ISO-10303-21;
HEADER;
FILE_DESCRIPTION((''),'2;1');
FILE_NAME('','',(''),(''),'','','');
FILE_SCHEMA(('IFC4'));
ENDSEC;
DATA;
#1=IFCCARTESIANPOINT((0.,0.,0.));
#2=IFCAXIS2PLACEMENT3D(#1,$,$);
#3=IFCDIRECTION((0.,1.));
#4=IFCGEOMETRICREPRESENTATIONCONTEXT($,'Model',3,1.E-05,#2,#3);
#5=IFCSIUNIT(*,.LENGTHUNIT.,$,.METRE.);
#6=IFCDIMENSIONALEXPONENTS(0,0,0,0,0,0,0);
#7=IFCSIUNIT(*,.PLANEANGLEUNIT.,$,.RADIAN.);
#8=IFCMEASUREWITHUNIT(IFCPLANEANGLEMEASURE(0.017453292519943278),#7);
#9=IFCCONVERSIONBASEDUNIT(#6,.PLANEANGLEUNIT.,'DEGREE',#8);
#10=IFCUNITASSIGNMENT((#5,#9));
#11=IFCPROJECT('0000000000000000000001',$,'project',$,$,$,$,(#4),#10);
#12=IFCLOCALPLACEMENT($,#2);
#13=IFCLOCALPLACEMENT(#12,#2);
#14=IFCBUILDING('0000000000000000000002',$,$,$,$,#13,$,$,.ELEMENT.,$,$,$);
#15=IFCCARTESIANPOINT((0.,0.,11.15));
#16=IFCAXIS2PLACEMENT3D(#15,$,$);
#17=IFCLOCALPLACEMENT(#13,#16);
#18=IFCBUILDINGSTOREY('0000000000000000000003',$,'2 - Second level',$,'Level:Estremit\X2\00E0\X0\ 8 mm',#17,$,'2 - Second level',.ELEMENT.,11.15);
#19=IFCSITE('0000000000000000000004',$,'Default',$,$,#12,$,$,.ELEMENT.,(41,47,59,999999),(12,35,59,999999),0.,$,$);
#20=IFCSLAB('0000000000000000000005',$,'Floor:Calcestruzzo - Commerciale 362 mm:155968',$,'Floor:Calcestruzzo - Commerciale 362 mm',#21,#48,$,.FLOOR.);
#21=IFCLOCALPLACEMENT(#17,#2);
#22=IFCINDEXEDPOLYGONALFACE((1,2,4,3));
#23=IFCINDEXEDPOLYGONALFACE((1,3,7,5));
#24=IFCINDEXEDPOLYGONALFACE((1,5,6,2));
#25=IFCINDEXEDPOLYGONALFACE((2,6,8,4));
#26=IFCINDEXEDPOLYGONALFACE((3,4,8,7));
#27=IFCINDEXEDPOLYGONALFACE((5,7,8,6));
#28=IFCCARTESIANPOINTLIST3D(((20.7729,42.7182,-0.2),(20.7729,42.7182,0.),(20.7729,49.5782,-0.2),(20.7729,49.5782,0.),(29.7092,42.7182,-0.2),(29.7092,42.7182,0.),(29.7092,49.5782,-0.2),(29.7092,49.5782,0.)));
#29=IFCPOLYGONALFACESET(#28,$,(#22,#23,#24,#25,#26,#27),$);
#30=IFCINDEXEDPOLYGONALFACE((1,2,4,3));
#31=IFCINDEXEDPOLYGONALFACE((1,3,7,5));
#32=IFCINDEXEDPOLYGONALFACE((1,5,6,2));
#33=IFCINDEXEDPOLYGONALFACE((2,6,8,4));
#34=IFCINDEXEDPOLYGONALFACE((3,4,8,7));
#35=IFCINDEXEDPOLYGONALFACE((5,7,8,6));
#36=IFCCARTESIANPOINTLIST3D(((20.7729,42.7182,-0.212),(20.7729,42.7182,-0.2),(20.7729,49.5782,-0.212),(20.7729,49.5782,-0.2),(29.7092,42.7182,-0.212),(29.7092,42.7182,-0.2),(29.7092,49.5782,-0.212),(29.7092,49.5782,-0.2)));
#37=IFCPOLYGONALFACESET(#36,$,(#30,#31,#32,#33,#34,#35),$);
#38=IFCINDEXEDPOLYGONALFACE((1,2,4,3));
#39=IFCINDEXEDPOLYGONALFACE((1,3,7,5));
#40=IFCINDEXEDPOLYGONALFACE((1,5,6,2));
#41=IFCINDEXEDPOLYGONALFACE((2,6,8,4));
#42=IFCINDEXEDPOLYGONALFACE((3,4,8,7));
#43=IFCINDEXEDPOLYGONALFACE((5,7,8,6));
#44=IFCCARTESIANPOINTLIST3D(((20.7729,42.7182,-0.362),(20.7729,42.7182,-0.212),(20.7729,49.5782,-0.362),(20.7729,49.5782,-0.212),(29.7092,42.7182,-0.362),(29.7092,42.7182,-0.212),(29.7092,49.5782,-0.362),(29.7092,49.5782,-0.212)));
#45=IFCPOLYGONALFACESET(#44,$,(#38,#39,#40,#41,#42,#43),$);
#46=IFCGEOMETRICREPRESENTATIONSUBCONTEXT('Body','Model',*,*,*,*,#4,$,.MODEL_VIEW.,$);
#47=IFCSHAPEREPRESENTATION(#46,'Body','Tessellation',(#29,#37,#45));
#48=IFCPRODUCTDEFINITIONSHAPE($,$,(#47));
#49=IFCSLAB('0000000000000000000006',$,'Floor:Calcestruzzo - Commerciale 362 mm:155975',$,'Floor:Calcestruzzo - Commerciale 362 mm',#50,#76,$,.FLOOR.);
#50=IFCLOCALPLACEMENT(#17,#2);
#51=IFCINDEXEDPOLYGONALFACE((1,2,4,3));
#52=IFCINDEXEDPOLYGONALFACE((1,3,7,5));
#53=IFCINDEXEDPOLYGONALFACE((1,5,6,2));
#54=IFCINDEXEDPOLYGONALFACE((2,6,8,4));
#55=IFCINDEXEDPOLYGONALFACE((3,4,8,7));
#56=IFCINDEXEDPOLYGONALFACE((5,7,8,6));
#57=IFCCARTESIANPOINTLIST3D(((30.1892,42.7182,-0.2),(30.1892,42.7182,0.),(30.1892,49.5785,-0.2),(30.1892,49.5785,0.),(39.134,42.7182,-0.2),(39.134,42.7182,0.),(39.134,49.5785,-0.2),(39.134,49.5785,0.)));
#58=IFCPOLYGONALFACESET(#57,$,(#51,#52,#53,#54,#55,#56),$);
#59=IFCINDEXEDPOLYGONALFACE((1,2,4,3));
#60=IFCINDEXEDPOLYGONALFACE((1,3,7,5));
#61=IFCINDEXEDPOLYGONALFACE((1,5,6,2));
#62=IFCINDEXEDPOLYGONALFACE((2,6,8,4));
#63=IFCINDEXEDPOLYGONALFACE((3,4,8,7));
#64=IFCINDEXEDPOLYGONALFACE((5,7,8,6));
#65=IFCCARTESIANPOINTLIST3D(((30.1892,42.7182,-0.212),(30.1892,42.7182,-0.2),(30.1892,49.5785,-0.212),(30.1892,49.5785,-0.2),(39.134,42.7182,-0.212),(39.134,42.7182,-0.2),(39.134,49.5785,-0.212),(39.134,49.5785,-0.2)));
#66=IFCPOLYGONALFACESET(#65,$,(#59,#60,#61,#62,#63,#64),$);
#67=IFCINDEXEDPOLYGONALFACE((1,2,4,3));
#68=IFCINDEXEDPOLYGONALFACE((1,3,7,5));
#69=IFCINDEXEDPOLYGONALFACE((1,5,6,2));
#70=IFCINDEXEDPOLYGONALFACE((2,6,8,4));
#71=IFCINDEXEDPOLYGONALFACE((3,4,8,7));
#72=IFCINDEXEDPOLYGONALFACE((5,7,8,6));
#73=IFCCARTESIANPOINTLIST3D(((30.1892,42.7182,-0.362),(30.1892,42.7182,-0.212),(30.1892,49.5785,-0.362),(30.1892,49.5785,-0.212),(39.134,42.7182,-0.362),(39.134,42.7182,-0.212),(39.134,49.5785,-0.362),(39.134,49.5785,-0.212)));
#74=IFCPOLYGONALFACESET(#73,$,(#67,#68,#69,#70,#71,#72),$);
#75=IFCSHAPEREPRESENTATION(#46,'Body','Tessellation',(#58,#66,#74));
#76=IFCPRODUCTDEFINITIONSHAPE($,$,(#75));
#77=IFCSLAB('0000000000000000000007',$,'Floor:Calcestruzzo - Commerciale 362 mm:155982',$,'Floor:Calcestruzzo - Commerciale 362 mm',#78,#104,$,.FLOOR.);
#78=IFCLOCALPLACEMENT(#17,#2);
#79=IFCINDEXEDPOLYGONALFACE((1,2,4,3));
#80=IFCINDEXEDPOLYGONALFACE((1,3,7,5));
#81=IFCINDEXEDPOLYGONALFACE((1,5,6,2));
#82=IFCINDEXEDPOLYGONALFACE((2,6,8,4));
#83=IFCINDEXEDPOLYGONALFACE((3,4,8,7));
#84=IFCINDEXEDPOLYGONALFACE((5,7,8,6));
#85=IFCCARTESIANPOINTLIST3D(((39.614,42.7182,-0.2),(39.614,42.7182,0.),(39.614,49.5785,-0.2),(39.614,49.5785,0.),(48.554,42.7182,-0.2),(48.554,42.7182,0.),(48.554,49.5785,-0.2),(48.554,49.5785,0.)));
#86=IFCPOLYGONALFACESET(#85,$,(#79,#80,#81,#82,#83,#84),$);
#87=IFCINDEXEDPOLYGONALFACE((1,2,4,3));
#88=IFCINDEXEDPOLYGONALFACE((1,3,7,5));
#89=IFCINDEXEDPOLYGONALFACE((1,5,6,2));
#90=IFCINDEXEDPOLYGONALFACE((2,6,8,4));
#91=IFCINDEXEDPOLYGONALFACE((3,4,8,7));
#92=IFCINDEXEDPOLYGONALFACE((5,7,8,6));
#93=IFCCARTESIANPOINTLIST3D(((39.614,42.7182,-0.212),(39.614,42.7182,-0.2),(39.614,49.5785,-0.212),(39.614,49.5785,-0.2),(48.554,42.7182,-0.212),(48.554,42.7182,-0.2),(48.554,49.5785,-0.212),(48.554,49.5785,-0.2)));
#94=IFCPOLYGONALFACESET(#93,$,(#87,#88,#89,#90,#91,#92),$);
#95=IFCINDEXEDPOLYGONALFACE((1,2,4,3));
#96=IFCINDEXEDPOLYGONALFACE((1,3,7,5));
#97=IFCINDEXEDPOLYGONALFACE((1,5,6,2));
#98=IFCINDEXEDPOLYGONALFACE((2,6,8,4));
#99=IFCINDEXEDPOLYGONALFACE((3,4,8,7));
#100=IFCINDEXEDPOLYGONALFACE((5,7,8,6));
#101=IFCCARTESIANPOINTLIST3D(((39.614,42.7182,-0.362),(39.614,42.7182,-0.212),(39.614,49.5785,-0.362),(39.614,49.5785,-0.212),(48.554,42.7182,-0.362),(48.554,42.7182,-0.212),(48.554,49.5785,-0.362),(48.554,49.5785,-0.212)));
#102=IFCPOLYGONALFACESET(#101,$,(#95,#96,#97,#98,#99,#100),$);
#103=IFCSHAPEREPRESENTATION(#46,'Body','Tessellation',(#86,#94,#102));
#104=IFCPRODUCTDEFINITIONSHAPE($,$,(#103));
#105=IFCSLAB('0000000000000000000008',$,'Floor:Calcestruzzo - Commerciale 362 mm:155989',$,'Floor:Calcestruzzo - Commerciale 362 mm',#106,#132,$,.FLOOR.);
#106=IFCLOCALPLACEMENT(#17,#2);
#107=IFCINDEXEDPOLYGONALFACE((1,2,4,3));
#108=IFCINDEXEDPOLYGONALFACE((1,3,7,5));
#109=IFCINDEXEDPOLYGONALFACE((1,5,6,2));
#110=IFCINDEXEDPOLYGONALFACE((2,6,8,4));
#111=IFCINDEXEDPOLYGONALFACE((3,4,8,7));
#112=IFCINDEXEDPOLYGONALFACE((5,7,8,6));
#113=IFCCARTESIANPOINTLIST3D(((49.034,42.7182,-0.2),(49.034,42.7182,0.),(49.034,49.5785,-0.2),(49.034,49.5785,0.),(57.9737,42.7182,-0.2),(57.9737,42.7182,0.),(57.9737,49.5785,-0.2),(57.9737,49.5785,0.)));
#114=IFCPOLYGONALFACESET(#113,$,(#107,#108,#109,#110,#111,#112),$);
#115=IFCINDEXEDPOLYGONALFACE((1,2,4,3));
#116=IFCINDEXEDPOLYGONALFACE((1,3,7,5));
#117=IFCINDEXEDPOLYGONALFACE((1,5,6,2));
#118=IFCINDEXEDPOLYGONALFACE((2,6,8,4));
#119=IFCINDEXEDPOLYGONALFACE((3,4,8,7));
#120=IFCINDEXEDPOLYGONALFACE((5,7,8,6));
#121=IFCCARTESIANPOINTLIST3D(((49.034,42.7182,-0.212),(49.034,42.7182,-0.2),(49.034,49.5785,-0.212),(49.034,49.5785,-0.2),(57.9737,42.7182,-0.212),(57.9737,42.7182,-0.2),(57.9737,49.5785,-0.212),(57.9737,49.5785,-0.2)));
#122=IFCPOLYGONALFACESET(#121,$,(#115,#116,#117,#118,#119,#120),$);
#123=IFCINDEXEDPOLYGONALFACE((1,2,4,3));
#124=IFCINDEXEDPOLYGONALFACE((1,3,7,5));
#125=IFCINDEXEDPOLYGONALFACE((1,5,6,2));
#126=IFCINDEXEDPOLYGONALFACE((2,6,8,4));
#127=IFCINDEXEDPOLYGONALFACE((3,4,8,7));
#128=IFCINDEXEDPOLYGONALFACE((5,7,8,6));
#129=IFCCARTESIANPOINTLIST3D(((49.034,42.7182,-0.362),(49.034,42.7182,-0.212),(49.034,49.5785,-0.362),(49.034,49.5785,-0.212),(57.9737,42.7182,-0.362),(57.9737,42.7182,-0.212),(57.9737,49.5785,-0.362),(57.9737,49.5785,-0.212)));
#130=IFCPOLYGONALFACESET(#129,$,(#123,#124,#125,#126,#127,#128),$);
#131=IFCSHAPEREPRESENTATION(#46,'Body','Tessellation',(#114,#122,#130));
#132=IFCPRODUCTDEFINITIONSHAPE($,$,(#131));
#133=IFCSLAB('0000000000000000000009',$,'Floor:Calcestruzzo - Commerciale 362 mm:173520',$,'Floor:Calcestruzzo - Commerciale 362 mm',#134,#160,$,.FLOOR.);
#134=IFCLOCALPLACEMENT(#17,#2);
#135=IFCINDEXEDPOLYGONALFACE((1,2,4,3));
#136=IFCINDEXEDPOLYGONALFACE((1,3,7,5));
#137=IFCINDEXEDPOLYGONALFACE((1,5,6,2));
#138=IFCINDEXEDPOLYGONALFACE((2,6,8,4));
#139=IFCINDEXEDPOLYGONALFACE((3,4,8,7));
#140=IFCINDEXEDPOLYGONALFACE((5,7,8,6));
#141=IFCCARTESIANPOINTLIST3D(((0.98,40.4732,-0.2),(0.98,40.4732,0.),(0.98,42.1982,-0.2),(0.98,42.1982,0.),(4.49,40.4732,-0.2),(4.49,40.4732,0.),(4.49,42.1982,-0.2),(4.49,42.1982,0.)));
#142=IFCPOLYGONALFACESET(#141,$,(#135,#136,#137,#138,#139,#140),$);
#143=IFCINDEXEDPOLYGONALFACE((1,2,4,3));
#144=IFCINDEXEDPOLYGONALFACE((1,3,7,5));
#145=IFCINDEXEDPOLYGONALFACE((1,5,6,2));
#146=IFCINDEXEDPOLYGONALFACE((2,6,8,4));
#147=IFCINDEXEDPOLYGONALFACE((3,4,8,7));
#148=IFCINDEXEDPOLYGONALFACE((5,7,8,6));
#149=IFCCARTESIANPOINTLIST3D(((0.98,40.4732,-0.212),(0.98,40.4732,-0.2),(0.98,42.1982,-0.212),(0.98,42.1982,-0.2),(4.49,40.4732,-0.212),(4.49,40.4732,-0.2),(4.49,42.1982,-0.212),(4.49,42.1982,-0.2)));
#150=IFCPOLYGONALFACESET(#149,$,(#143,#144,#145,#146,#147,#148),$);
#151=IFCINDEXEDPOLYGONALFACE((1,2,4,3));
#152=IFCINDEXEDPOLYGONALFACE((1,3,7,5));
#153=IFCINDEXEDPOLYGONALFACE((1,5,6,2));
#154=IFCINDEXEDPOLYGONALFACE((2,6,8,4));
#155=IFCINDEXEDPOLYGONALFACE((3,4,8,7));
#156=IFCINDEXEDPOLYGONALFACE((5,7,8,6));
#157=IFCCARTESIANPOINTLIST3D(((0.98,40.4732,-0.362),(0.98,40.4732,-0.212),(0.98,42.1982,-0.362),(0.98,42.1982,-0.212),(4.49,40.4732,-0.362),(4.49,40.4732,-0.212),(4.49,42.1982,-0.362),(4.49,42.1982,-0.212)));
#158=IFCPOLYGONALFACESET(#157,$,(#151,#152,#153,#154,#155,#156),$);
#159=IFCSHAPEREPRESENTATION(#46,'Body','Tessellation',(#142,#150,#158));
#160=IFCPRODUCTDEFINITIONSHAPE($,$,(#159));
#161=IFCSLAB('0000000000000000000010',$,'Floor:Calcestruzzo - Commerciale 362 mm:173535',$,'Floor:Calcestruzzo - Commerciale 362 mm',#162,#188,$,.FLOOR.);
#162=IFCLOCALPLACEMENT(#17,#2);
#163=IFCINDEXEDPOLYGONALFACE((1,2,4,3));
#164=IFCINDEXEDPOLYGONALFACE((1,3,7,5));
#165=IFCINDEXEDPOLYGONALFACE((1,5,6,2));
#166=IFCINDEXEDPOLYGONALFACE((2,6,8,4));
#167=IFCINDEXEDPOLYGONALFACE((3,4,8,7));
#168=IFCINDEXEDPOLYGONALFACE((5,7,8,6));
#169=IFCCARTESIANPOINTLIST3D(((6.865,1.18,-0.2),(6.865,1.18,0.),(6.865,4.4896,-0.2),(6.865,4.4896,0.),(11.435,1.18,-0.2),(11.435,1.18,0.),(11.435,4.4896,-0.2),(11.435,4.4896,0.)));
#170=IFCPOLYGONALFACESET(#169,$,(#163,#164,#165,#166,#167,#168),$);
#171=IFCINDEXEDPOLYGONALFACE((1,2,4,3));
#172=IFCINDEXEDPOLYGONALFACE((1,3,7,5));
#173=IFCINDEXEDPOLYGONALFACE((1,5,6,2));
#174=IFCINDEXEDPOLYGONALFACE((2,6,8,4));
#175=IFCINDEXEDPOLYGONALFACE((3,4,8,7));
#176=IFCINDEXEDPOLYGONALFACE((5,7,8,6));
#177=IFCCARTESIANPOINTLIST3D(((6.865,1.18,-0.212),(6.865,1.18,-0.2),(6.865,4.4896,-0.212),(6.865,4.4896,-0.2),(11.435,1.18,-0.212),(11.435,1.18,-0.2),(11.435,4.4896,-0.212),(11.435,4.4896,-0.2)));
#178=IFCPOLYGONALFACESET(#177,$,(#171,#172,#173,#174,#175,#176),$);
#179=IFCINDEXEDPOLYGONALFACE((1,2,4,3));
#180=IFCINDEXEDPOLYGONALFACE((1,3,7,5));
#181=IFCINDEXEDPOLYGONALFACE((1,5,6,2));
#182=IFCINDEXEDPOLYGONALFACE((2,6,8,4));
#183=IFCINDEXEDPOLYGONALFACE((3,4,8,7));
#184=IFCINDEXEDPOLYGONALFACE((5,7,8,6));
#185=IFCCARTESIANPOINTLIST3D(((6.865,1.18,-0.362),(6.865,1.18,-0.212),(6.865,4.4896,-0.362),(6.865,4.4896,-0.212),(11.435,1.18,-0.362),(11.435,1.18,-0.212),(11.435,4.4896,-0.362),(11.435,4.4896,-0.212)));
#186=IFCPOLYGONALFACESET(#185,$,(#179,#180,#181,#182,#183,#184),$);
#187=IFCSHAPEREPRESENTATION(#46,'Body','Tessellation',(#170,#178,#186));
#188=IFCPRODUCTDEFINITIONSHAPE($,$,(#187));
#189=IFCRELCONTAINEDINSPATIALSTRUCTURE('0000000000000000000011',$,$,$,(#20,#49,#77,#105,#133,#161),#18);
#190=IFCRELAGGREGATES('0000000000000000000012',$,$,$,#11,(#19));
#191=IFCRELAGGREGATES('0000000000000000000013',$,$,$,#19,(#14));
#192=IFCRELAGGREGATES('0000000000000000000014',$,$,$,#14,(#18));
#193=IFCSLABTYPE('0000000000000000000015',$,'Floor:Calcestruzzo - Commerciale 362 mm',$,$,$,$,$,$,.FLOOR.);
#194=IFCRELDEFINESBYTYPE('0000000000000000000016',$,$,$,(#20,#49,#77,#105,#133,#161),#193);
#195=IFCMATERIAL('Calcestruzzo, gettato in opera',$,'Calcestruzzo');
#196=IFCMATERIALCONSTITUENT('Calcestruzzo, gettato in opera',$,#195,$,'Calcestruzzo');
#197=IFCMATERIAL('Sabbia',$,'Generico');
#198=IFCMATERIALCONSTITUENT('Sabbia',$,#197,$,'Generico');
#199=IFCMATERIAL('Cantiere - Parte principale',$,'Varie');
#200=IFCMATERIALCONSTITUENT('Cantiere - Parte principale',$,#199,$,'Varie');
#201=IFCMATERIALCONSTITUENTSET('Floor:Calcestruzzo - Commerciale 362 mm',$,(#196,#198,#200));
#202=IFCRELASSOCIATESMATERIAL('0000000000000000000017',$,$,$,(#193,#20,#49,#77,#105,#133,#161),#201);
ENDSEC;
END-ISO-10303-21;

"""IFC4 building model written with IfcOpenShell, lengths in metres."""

from ifc_helpers import new_model, entity, si_unit, converted_unit, direction, frame, origin, place, context, subcontext, project, spatial, indexed_curve, outline, extrude, material, constituent, constituent_set, type_object, element, save


model = new_model("IFC4")

# Units and contexts
model_context = context("Model", 3, precision=1e-05, world=origin(), true_north=direction((0.0, 1.0)))
body_context = subcontext(model_context, "Body", "Model", "MODEL_VIEW")
ifc_project = project(units=[si_unit("LENGTHUNIT", "METRE"), converted_unit("PLANEANGLEUNIT", "DEGREE", entity("IfcPlaneAngleMeasure", 0.017453292519943278), si_unit("PLANEANGLEUNIT", "RADIAN"), dimensions=[0, 0, 0, 0, 0, 0, 0])], contexts=[model_context])

# Site, building, storey
site_placement = place(None, origin())
site = spatial("IfcSite", under=ifc_project, at=site_placement, Name="Default", CompositionType="ELEMENT", RefLatitude=(41, 47, 59, 999999), RefLongitude=(12, 35, 59, 999999), RefElevation=0.0)
building_placement = place(site_placement, origin())
building = spatial("IfcBuilding", under=site, at=building_placement, CompositionType="ELEMENT")
storey_placement = place(building_placement, frame((0.0, 0.0, 11.15)))
storey = spatial("IfcBuildingStorey", under=building, at=storey_placement, Name="2 - Second level", ObjectType="Level:Estremità 8 mm", LongName="2 - Second level", CompositionType="ELEMENT", Elevation=11.15)

# Slabs
ifc_material_1 = material(Name="Calcestruzzo, gettato in opera", Category="Calcestruzzo")
ifc_constituent_1 = constituent(ifc_material_1, Name="Calcestruzzo, gettato in opera", Category="Calcestruzzo")
ifc_material_2 = material(Name="Sabbia", Category="Generico")
ifc_constituent_2 = constituent(ifc_material_2, Name="Sabbia", Category="Generico")
ifc_material_3 = material(Name="Cantiere - Parte principale", Category="Varie")
ifc_constituent_3 = constituent(ifc_material_3, Name="Cantiere - Parte principale", Category="Varie")
ifc_constituent_set = constituent_set(constituents=[ifc_constituent_1, ifc_constituent_2, ifc_constituent_3], Name="Floor:Calcestruzzo - Commerciale 362 mm")
slab_type = type_object("IfcSlabType", Name="Floor:Calcestruzzo - Commerciale 362 mm", PredefinedType="FLOOR", material=ifc_constituent_set)
slab_1_placement = place(storey_placement, origin())
element("IfcSlab", 1, at=slab_1_placement, inside=storey, type_object=slab_type, material=ifc_constituent_set, Name="Floor:Calcestruzzo - Commerciale 362 mm:155968", ObjectType="Floor:Calcestruzzo - Commerciale 362 mm", PredefinedType="FLOOR", context=body_context, shape_type="SweptSolid", body=[
    extrude(outline(indexed_curve([(-3.43, -4.4681), (3.43, -4.4681), (3.43, 4.4681), (-3.43, 4.4681), (-3.43, -4.4681)], self_intersect=False)), frame((25.2411, 46.1482, -0.2), z_axis=(0.0, 0.0, 1.0), x_axis=(0.0, -1.0, 0.0)), (0.0, 0.0, 1.0), 0.2),
    extrude(outline(indexed_curve([(-3.43, -4.4681), (3.43, -4.4681), (3.43, 4.4681), (-3.43, 4.4681), (-3.43, -4.4681)], self_intersect=False)), frame((25.2411, 46.1482, -0.212), z_axis=(0.0, 0.0, 1.0), x_axis=(0.0, -1.0, 0.0)), (0.0, 0.0, 1.0), 0.012),
    extrude(outline(indexed_curve([(-3.43, -4.4681), (3.43, -4.4681), (3.43, 4.4681), (-3.43, 4.4681), (-3.43, -4.4681)], self_intersect=False)), frame((25.2411, 46.1482, -0.362), z_axis=(0.0, 0.0, 1.0), x_axis=(0.0, -1.0, 0.0)), (0.0, 0.0, 1.0), 0.15),
])
slab_2_placement = place(storey_placement, origin())
element("IfcSlab", 2, at=slab_2_placement, inside=storey, type_object=slab_type, material=ifc_constituent_set, Name="Floor:Calcestruzzo - Commerciale 362 mm:155975", ObjectType="Floor:Calcestruzzo - Commerciale 362 mm", PredefinedType="FLOOR", context=body_context, shape_type="SweptSolid", body=[
    extrude(outline(indexed_curve([(-3.4302, -4.4724), (3.4302, -4.4724), (3.4302, 4.4724), (-3.4302, 4.4724), (-3.4302, -4.4724)], self_intersect=False)), frame((34.6616, 46.1483, -0.2), z_axis=(0.0, 0.0, 1.0), x_axis=(0.0, -1.0, 0.0)), (0.0, 0.0, 1.0), 0.2),
    extrude(outline(indexed_curve([(-3.4302, -4.4724), (3.4302, -4.4724), (3.4302, 4.4724), (-3.4302, 4.4724), (-3.4302, -4.4724)], self_intersect=False)), frame((34.6616, 46.1483, -0.212), z_axis=(0.0, 0.0, 1.0), x_axis=(0.0, -1.0, 0.0)), (0.0, 0.0, 1.0), 0.012),
    extrude(outline(indexed_curve([(-3.4302, -4.4724), (3.4302, -4.4724), (3.4302, 4.4724), (-3.4302, 4.4724), (-3.4302, -4.4724)], self_intersect=False)), frame((34.6616, 46.1483, -0.362), z_axis=(0.0, 0.0, 1.0), x_axis=(0.0, -1.0, 0.0)), (0.0, 0.0, 1.0), 0.15),
])
slab_3_placement = place(storey_placement, origin())
element("IfcSlab", 3, at=slab_3_placement, inside=storey, type_object=slab_type, material=ifc_constituent_set, Name="Floor:Calcestruzzo - Commerciale 362 mm:155982", ObjectType="Floor:Calcestruzzo - Commerciale 362 mm", PredefinedType="FLOOR", context=body_context, shape_type="SweptSolid", body=[
    extrude(outline(indexed_curve([(-3.4302, -4.47), (3.4302, -4.47), (3.4302, 4.47), (-3.4302, 4.47), (-3.4302, -4.47)], self_intersect=False)), frame((44.084, 46.1483, -0.2), z_axis=(0.0, 0.0, 1.0), x_axis=(0.0, -1.0, 0.0)), (0.0, 0.0, 1.0), 0.2),
    extrude(outline(indexed_curve([(-3.4302, -4.47), (3.4302, -4.47), (3.4302, 4.47), (-3.4302, 4.47), (-3.4302, -4.47)], self_intersect=False)), frame((44.084, 46.1483, -0.212), z_axis=(0.0, 0.0, 1.0), x_axis=(0.0, -1.0, 0.0)), (0.0, 0.0, 1.0), 0.012),
    extrude(outline(indexed_curve([(-3.4302, -4.47), (3.4302, -4.47), (3.4302, 4.47), (-3.4302, 4.47), (-3.4302, -4.47)], self_intersect=False)), frame((44.084, 46.1483, -0.362), z_axis=(0.0, 0.0, 1.0), x_axis=(0.0, -1.0, 0.0)), (0.0, 0.0, 1.0), 0.15),
])
slab_4_placement = place(storey_placement, origin())
element("IfcSlab", 4, at=slab_4_placement, inside=storey, type_object=slab_type, material=ifc_constituent_set, Name="Floor:Calcestruzzo - Commerciale 362 mm:155989", ObjectType="Floor:Calcestruzzo - Commerciale 362 mm", PredefinedType="FLOOR", context=body_context, shape_type="SweptSolid", body=[
    extrude(outline(indexed_curve([(-3.4302, -4.4698), (3.4302, -4.4698), (3.4302, 4.4698), (-3.4302, 4.4698), (-3.4302, -4.4698)], self_intersect=False)), frame((53.5038, 46.1483, -0.2), z_axis=(0.0, 0.0, 1.0), x_axis=(0.0, -1.0, 0.0)), (0.0, 0.0, 1.0), 0.2),
    extrude(outline(indexed_curve([(-3.4302, -4.4698), (3.4302, -4.4698), (3.4302, 4.4698), (-3.4302, 4.4698), (-3.4302, -4.4698)], self_intersect=False)), frame((53.5038, 46.1483, -0.212), z_axis=(0.0, 0.0, 1.0), x_axis=(0.0, -1.0, 0.0)), (0.0, 0.0, 1.0), 0.012),
    extrude(outline(indexed_curve([(-3.4302, -4.4698), (3.4302, -4.4698), (3.4302, 4.4698), (-3.4302, 4.4698), (-3.4302, -4.4698)], self_intersect=False)), frame((53.5038, 46.1483, -0.362), z_axis=(0.0, 0.0, 1.0), x_axis=(0.0, -1.0, 0.0)), (0.0, 0.0, 1.0), 0.15),
])
slab_5_placement = place(storey_placement, origin())
element("IfcSlab", 5, at=slab_5_placement, inside=storey, type_object=slab_type, material=ifc_constituent_set, Name="Floor:Calcestruzzo - Commerciale 362 mm:173520", ObjectType="Floor:Calcestruzzo - Commerciale 362 mm", PredefinedType="FLOOR", context=body_context, shape_type="SweptSolid", body=[
    extrude(outline(indexed_curve([(-1.755, -0.8625), (1.755, -0.8625), (1.755, 0.8625), (-1.755, 0.8625), (-1.755, -0.8625)], self_intersect=False)), frame((2.735, 41.3357, -0.2)), (0.0, 0.0, 1.0), 0.2),
    extrude(outline(indexed_curve([(-1.755, -0.8625), (1.755, -0.8625), (1.755, 0.8625), (-1.755, 0.8625), (-1.755, -0.8625)], self_intersect=False)), frame((2.735, 41.3357, -0.212)), (0.0, 0.0, 1.0), 0.012),
    extrude(outline(indexed_curve([(-1.755, -0.8625), (1.755, -0.8625), (1.755, 0.8625), (-1.755, 0.8625), (-1.755, -0.8625)], self_intersect=False)), frame((2.735, 41.3357, -0.362)), (0.0, 0.0, 1.0), 0.15),
])
slab_6_placement = place(storey_placement, origin())
element("IfcSlab", 6, at=slab_6_placement, inside=storey, type_object=slab_type, material=ifc_constituent_set, Name="Floor:Calcestruzzo - Commerciale 362 mm:173535", ObjectType="Floor:Calcestruzzo - Commerciale 362 mm", PredefinedType="FLOOR", context=body_context, shape_type="SweptSolid", body=[
    extrude(outline(indexed_curve([(-1.6548, -2.285), (1.6548, -2.285), (1.6548, 2.285), (-1.6548, 2.285), (-1.6548, -2.285)], self_intersect=False)), frame((9.15, 2.8348, -0.2), z_axis=(0.0, 0.0, 1.0), x_axis=(0.0, 1.0, 0.0)), (0.0, 0.0, 1.0), 0.2),
    extrude(outline(indexed_curve([(-1.6548, -2.285), (1.6548, -2.285), (1.6548, 2.285), (-1.6548, 2.285), (-1.6548, -2.285)], self_intersect=False)), frame((9.15, 2.8348, -0.212), z_axis=(0.0, 0.0, 1.0), x_axis=(0.0, 1.0, 0.0)), (0.0, 0.0, 1.0), 0.012),
    extrude(outline(indexed_curve([(-1.6548, -2.285), (1.6548, -2.285), (1.6548, 2.285), (-1.6548, 2.285), (-1.6548, -2.285)], self_intersect=False)), frame((9.15, 2.8348, -0.362), z_axis=(0.0, 0.0, 1.0), x_axis=(0.0, 1.0, 0.0)), (0.0, 0.0, 1.0), 0.15),
])

save(model, "model.ifc")
